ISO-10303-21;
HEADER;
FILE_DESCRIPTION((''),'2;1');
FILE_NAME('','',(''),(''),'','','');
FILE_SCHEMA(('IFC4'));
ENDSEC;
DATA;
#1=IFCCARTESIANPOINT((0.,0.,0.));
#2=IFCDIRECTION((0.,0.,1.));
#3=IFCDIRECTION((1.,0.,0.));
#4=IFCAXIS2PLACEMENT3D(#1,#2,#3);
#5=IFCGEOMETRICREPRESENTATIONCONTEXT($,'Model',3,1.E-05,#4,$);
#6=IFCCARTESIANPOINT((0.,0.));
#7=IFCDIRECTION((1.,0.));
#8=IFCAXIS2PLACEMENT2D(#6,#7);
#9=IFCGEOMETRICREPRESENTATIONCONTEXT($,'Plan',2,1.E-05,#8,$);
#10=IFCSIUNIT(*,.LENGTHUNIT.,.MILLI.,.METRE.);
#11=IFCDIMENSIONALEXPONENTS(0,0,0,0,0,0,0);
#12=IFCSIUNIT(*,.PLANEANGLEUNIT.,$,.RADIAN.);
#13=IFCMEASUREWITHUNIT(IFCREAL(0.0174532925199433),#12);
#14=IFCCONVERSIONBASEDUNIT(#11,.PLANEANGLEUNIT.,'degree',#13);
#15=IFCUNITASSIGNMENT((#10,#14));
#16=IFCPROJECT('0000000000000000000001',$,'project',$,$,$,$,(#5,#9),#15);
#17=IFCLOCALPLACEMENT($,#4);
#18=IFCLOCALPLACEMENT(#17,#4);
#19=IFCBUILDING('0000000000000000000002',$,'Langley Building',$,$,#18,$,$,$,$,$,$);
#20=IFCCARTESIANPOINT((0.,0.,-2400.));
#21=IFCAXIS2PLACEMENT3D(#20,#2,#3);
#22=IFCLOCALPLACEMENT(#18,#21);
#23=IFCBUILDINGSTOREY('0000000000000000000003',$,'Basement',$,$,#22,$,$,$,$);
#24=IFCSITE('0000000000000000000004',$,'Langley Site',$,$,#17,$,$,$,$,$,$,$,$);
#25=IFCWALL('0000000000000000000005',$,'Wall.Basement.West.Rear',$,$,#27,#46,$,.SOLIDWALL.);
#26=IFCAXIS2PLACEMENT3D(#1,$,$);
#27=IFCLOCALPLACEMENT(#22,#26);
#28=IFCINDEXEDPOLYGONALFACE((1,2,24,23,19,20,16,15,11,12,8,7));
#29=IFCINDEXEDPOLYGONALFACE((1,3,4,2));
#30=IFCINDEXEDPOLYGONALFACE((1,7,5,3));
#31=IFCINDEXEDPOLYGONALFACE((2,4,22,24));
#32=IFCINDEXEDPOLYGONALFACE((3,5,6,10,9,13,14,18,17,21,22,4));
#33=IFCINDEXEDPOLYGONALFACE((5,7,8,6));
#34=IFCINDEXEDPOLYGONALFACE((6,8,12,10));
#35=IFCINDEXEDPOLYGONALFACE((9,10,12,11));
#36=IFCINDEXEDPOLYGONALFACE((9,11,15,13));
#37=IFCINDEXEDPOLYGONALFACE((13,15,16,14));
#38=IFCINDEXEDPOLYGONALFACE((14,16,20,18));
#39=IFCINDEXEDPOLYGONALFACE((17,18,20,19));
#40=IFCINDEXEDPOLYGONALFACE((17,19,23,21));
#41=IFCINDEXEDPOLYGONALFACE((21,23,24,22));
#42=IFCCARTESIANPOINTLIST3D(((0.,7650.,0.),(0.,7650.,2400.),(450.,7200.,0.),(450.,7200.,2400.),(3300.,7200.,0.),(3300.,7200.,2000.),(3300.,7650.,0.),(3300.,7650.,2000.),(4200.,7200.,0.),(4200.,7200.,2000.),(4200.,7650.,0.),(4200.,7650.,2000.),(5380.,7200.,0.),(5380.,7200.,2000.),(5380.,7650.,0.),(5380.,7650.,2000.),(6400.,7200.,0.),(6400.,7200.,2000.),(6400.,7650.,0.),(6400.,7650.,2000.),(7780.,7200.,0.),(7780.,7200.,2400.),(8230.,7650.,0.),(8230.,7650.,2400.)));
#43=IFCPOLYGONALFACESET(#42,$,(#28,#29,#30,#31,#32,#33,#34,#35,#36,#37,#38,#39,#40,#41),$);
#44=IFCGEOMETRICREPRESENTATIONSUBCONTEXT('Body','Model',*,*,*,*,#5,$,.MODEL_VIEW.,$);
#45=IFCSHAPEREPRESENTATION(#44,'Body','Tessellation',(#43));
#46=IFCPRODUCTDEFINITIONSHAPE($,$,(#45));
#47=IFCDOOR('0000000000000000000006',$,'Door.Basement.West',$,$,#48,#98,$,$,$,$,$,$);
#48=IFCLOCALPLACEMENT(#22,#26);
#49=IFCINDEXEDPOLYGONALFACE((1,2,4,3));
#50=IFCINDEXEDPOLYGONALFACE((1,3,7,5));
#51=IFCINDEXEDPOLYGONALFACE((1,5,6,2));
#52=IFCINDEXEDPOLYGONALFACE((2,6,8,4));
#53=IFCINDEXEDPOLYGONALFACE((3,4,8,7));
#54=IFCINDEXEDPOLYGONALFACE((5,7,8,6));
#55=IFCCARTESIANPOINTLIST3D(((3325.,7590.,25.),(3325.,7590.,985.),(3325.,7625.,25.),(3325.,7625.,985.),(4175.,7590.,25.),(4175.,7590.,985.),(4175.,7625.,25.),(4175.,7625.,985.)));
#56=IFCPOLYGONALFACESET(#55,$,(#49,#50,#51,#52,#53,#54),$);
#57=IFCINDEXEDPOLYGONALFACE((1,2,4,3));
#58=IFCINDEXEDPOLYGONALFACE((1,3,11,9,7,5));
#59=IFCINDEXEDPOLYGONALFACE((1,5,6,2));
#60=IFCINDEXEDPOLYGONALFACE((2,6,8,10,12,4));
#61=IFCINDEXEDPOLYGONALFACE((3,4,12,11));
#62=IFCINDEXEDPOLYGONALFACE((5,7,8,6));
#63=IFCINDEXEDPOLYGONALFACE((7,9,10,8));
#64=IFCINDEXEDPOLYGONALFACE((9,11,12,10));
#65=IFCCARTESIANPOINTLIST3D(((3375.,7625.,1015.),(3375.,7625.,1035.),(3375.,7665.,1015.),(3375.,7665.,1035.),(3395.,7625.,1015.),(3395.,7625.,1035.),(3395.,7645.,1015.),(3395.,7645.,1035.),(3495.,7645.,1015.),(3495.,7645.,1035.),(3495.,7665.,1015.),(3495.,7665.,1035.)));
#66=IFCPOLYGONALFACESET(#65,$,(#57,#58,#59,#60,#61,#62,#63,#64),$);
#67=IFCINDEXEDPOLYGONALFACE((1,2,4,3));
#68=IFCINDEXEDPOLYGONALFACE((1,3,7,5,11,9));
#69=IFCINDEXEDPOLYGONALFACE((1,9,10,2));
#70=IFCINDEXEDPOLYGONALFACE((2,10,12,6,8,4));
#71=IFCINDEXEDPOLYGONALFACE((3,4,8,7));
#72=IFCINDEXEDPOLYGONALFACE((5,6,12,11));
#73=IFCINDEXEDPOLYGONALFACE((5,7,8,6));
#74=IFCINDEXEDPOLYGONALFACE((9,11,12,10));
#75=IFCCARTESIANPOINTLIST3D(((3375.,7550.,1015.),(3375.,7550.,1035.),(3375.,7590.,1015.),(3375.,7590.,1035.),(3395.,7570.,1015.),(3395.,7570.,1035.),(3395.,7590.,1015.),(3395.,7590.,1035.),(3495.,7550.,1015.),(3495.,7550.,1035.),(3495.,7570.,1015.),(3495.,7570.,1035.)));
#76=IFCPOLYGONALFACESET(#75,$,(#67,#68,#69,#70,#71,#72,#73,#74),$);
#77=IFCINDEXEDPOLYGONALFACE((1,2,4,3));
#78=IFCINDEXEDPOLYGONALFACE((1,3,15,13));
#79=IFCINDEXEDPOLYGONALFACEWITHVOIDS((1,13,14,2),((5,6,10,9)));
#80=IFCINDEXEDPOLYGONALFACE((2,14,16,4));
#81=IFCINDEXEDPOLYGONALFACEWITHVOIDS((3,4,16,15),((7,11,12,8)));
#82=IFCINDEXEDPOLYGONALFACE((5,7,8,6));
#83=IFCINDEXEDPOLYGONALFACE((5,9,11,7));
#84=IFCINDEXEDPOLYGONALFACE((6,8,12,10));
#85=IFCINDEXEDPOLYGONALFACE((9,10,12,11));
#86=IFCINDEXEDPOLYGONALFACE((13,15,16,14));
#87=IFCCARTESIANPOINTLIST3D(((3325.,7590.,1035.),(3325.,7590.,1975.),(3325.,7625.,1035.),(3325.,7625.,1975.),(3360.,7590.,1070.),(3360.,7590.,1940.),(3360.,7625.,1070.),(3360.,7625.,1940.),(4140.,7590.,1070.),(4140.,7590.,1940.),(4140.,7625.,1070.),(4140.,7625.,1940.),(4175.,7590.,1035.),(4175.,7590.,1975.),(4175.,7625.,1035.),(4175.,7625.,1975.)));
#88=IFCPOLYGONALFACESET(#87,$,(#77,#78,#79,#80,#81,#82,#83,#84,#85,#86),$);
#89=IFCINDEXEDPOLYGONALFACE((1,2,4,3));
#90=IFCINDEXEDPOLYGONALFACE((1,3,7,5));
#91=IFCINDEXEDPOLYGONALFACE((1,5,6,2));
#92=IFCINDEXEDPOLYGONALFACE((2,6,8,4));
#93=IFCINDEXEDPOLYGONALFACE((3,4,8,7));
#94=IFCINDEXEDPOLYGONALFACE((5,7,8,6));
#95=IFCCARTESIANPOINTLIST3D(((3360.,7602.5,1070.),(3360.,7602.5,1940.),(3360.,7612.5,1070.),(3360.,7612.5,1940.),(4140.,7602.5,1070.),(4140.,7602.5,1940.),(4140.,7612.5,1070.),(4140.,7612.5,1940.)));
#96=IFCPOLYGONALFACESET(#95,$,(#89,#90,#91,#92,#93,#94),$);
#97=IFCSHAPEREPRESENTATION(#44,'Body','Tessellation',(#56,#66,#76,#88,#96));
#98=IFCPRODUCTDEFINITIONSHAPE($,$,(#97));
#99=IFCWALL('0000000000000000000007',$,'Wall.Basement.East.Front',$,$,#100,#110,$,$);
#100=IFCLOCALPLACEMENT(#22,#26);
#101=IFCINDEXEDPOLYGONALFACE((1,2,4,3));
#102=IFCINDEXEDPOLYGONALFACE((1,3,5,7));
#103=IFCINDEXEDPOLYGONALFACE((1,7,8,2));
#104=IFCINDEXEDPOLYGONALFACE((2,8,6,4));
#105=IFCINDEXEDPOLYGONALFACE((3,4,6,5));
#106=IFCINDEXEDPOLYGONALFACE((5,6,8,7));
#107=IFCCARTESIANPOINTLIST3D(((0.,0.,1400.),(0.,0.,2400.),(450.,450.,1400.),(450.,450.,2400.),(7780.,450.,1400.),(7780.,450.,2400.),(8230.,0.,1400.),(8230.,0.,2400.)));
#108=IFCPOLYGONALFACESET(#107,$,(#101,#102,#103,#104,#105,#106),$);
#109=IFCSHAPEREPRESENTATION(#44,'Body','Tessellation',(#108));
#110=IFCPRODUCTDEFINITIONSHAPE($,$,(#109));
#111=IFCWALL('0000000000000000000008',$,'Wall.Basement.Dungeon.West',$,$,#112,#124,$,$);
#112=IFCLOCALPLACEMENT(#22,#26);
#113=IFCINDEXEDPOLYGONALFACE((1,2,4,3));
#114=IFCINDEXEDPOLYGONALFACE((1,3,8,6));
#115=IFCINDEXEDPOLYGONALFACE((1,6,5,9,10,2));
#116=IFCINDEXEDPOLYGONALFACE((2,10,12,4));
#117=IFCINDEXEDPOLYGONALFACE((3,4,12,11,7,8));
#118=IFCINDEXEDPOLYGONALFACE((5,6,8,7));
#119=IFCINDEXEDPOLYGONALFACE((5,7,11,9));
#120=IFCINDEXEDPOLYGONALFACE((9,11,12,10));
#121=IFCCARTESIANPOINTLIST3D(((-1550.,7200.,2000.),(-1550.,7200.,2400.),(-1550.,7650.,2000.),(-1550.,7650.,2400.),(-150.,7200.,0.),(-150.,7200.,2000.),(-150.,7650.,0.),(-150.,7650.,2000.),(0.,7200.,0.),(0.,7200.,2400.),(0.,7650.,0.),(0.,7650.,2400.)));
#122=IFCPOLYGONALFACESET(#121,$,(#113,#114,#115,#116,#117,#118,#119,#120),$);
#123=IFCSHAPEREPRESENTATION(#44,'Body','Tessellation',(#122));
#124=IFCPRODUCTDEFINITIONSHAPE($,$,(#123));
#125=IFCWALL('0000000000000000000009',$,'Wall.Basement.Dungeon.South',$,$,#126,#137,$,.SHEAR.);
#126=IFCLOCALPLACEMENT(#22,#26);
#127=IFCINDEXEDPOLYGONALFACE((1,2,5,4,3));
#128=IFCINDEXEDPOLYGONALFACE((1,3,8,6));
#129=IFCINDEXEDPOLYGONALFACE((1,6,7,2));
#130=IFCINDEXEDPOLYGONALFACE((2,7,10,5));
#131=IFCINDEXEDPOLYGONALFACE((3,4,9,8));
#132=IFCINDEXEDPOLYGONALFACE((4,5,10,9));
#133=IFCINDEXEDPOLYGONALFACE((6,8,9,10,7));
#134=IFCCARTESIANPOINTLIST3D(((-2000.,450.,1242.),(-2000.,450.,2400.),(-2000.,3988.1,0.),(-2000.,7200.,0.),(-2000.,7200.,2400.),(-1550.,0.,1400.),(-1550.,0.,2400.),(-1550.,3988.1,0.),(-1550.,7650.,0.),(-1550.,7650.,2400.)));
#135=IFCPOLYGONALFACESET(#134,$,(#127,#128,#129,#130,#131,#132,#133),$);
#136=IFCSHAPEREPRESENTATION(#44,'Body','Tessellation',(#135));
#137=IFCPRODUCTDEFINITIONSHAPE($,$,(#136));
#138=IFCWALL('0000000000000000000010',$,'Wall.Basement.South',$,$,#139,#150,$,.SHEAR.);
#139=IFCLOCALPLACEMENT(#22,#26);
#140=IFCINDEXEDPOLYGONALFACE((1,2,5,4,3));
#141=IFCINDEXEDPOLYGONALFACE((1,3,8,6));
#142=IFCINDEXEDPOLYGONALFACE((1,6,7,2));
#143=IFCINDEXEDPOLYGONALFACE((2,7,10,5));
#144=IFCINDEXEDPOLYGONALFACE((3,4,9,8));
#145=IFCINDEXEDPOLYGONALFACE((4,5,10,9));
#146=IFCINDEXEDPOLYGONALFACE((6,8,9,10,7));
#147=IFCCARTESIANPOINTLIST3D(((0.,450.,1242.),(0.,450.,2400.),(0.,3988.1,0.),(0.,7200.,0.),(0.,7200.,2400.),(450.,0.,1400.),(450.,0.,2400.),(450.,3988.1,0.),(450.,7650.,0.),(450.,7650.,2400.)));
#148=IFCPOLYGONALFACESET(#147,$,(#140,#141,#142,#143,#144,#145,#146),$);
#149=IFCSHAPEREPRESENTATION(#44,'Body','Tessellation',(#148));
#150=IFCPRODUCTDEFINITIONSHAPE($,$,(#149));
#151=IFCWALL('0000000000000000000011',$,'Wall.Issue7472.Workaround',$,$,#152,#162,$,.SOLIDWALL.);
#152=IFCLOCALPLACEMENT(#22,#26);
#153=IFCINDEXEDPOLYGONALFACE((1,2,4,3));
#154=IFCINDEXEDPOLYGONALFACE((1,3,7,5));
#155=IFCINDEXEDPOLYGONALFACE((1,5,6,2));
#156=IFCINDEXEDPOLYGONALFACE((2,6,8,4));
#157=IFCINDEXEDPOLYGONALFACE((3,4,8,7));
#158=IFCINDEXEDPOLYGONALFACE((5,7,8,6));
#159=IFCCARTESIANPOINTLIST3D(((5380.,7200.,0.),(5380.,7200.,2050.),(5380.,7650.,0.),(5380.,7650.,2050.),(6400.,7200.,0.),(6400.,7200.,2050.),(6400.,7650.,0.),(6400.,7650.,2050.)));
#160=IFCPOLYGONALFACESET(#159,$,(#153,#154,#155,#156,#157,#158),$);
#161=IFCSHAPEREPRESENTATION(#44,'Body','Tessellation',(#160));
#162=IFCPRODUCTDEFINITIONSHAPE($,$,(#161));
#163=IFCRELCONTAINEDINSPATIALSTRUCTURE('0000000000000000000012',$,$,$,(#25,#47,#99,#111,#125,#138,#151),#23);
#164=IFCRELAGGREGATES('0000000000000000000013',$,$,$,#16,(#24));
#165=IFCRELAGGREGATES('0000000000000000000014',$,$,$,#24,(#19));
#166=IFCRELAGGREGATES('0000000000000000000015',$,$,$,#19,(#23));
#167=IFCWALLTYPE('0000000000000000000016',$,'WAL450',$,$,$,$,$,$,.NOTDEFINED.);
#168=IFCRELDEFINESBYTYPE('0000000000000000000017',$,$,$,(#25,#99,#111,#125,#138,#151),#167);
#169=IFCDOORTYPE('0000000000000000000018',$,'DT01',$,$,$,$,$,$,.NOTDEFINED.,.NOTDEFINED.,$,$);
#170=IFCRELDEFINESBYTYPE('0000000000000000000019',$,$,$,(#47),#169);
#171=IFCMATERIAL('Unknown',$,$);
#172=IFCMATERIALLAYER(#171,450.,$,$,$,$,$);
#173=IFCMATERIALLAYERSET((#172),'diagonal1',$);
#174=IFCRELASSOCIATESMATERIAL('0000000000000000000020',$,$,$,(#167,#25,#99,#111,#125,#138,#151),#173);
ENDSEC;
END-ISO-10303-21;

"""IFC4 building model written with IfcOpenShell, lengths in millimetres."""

from ifc_helpers import new_model, entity, si_unit, converted_unit, frame, origin_with_axes, origin_2d_with_axis, place, context, subcontext, project, spatial, line, indexed_curve, outline, extrude, clip, halfspace, shape, source, transform, mapped, material, layer, layer_set, layer_usage, type_object, type_shapes, element, fill, save


model = new_model("IFC4")

# Units and contexts
model_context = context("Model", 3, precision=1e-05, world=origin_with_axes())
plan_context = context("Plan", 2, precision=1e-05, world=origin_2d_with_axis())
body_context_1 = subcontext(model_context, "Body", "Model", "MODEL_VIEW")
body_context_2 = subcontext(plan_context, "Body", "Plan", "PLAN_VIEW")
ifc_project = project(units=[si_unit("LENGTHUNIT", "METRE", prefix="MILLI"), converted_unit("PLANEANGLEUNIT", "degree", entity("IfcReal", 0.0174532925199433), si_unit("PLANEANGLEUNIT", "RADIAN"), dimensions=[0, 0, 0, 0, 0, 0, 0])], contexts=[model_context, plan_context])

# Site, building, storey
site_placement = place(None, origin_with_axes())
site = spatial("IfcSite", under=ifc_project, at=site_placement, Name="Langley Site")
building_placement = place(site_placement, origin_with_axes())
building = spatial("IfcBuilding", under=site, at=building_placement, Name="Langley Building")
storey_placement = place(building_placement, frame((0.0, 0.0, -2400.0), z_axis=(0.0, 0.0, 1.0), x_axis=(1.0, 0.0, 0.0)))
storey = spatial("IfcBuildingStorey", under=building, at=storey_placement, Name="Basement")

# Shared definitions
ifc_material = material(Name="Unknown")

# Wall, openings, door
ifc_layer_1 = layer(ifc_material, 450.0)
ifc_layer_set_1 = layer_set([ifc_layer_1], Name="diagonal1")
ifc_layer_usage_1 = layer_usage(ifc_layer_set_1, "AXIS2", "POSITIVE", 0.0)
wall_type_1 = type_object("IfcWallType", Name="WAL450", PredefinedType="NOTDEFINED", material=ifc_layer_set_1)
wall_1_placement = place(storey_placement, frame((8230.0, 7650.0, 0.0), z_axis=(0.0, 0.0, 1.0), x_axis=(-1.0, 0.0, 0.0)))
wall_1 = element("IfcWall", 1, at=wall_1_placement, inside=storey, type_object=wall_type_1, material=ifc_layer_usage_1, Name="Wall.Basement.West.Rear", PredefinedType="SOLIDWALL", context=body_context_1, shape_type="SweptSolid", body=[
    extrude(outline(indexed_curve([(0.0, 0.0), (450.0, 450.0), (7780.0, 450.0), (8230.0, 0.0)], segments=[line(1, 2, 3, 4, 1)])), origin_with_axes(), (0.0, 0.0, 1.0), 2400.0),
])
shared_shape_1 = source(origin_with_axes(), body_context_1, "Body", "SweptSolid", [
    extrude(outline(indexed_curve([(0.0, 0.0), (900.0, 0.0), (900.0, 2000.0), (0.0, 2000.0)], segments=[line(1, 2, 3, 4, 1)])), frame((0.0, -600.0, 0.0), z_axis=(0.0, -1.0, 0.0), x_axis=(1.0, 0.0, 0.0)), (0.0, 0.0, -1.0), 1200.0),
])
opening_1_placement = place(wall_1_placement, frame((4030.0, 0.0, 0.0), z_axis=(0.0, 0.0, 1.0), x_axis=(1.0, 0.0, 0.0)))
opening_1 = element("IfcOpeningElement", 2, at=opening_1_placement, cuts=wall_1, PredefinedType="OPENING", context=body_context_1, shape_type="MappedRepresentation", body=[
    mapped(shared_shape_1, transform((0.0, 0.0, 0.0), x_axis=(1.0, 0.0, 0.0), y_axis=(0.0, 1.0, 0.0), z_axis=(0.0, 0.0, 1.0), scale=1.0)),
])
shared_shape_2 = source(origin_with_axes(), body_context_1, "Body", "SweptSolid", [
    extrude(outline(indexed_curve([(0.0, 2000.0), (1020.0, 2000.0), (1020.0, 0.0), (0.0, 0.0), (0.0, 2000.0)])), frame((0.0, -600.0, 0.0), z_axis=(0.0, -1.0, 0.0), x_axis=(1.0, 0.0, 0.0)), (0.0, 0.0, -1.0), 1200.0),
])
opening_2_placement = place(wall_1_placement, frame((1830.0, 0.0, 0.0), z_axis=(0.0, 0.0, 1.0), x_axis=(1.0, 0.0, 0.0)))
element("IfcOpeningElement", 3, at=opening_2_placement, cuts=wall_1, PredefinedType="OPENING", context=body_context_1, shape_type="MappedRepresentation", body=[
    mapped(shared_shape_2, transform((0.0, 0.0, 0.0), x_axis=(1.0, 0.0, 0.0), y_axis=(0.0, 1.0, 0.0), z_axis=(0.0, 0.0, 1.0), scale=1.0)),
])
door_type_1 = type_object("IfcDoorType", Name="DT01", OperationType="NOTDEFINED", PredefinedType="NOTDEFINED")
shared_shape_3 = source(origin_with_axes(), body_context_1, "Body", "SweptSolid", [
    extrude(outline(indexed_curve([(0.0, 0.0), (850.0, 0.0), (850.0, 35.0), (0.0, 35.0)], segments=[line(1, 2, 3, 4, 1)])), frame((25.0, 25.0, 25.0), z_axis=(0.0, 0.0, 1.0), x_axis=(1.0, 0.0, 0.0)), (0.0, 0.0, 1.0), 960.0),
    extrude(outline(indexed_curve([(0.0, 0.0), (0.0, -40.0), (-120.0, -40.0), (-120.0, -20.0), (-20.0, -20.0), (-20.0, 0.0)], segments=[line(1, 2, 3, 4, 5, 6, 1)])), frame((825.0, 25.0, 1015.0), z_axis=(0.0, 0.0, 1.0), x_axis=(1.0, 0.0, 0.0)), (0.0, 0.0, 1.0), 20.0),
    extrude(outline(indexed_curve([(0.0, 0.0), (0.0, 40.0), (-120.0, 40.0), (-120.0, 20.0), (-20.0, 20.0), (-20.0, 0.0)], segments=[line(1, 2, 3, 4, 5, 6, 1)])), frame((825.0, 60.0, 1015.0), z_axis=(0.0, 0.0, 1.0), x_axis=(1.0, 0.0, 0.0)), (0.0, 0.0, 1.0), 20.0),
    extrude(outline(indexed_curve([(0.0, 0.0), (850.0, 0.0), (850.0, 940.0), (0.0, 940.0)], segments=[line(1, 2, 3, 4, 1)]), holes=[indexed_curve([(35.0, 35.0), (815.0, 35.0), (815.0, 905.0), (35.0, 905.0)], segments=[line(1, 2, 3, 4, 1)])]), frame((25.0, 25.0, 1035.0), z_axis=(0.0, -1.0, 0.0), x_axis=(1.0, 0.0, 0.0)), (0.0, 0.0, -1.0), 35.0),
    extrude(outline(indexed_curve([(35.0, 35.0), (815.0, 35.0), (815.0, 905.0), (35.0, 905.0)], segments=[line(1, 2, 3, 4, 1)])), frame((25.0, 37.5, 1035.0), z_axis=(0.0, -1.0, 0.0), x_axis=(1.0, 0.0, 0.0)), (0.0, 0.0, -1.0), 10.0),
])
shared_shape_4 = source(origin_with_axes(), body_context_2, "Body", "Curve2D", [
    entity("IfcIndexedPolyCurve", entity("IfcCartesianPointList2D", [[0.0, 0.0], [0.0, 50.0], [25.0, 50.0], [25.0, 25.0], [50.0, 25.0], [50.0, 0.0]]), [entity("IfcLineIndex", [1, 2, 3, 4, 5, 6, 1])]),
    entity("IfcIndexedPolyCurve", entity("IfcCartesianPointList2D", [[900.0, 0.0], [900.0, 50.0], [875.0, 50.0], [875.0, 25.0], [850.0, 25.0], [850.0, 0.0]]), [entity("IfcLineIndex", [1, 2, 3, 4, 5, 6, 1])]),
    entity("IfcTrimmedCurve", entity("IfcEllipse", entity("IfcAxis2Placement2D", entity("IfcCartesianPoint", [60.0, 50.0]), entity("IfcDirection", [1.0, 0.0])), 815.0, 850.0), [entity("IfcCartesianPoint", [875.0, 50.0])], [entity("IfcCartesianPoint", [60.0, 900.0])], True, "CARTESIAN"),
    entity("IfcIndexedPolyCurve", entity("IfcCartesianPointList2D", [[25.0, 50.0], [60.0, 50.0], [60.0, 900.0], [25.0, 900.0]]), [entity("IfcLineIndex", [1, 2, 3, 4, 1])]),
])
type_shapes(door_type_1, [shared_shape_3, shared_shape_4])
door_1_placement = place(opening_1_placement, origin_with_axes())
door_1 = element("IfcDoor", 4, at=door_1_placement, inside=storey, type_object=door_type_1, Name="Door.Basement.West", shapes=[
    shape(body_context_1, "Body", "MappedRepresentation", [mapped(shared_shape_3, transform((0.0, 0.0, 0.0), x_axis=(1.0, 0.0, 0.0), y_axis=(0.0, 1.0, 0.0), z_axis=(0.0, 0.0, 1.0), scale=1.0))]),
    shape(body_context_2, "Body", "MappedRepresentation", [mapped(shared_shape_4, transform((0.0, 0.0, 0.0), x_axis=(1.0, 0.0, 0.0), y_axis=(0.0, 1.0, 0.0), z_axis=(0.0, 0.0, 1.0), scale=1.0))]),
])
fill(opening_1, door_1)

# Wall
ifc_layer_usage_2 = layer_usage(ifc_layer_set_1, "AXIS2", "POSITIVE", 0.0)
wall_2_placement = place(storey_placement, frame((450.0, 0.0, 1400.0), z_axis=(0.0, 0.0, 1.0), x_axis=(1.0, 0.0, 0.0)))
element("IfcWall", 5, at=wall_2_placement, inside=storey, type_object=wall_type_1, material=ifc_layer_usage_2, Name="Wall.Basement.East.Front", context=body_context_1, shape_type="SweptSolid", body=[
    extrude(outline(indexed_curve([(-450.0, 0.0), (0.0, 450.0), (7330.0, 450.0), (7780.0, 0.0)], segments=[line(1, 2, 3, 4, 1)])), origin_with_axes(), (0.0, 0.0, 1.0), 1000.0),
])

# Wall, opening
ifc_layer_usage_3 = layer_usage(ifc_layer_set_1, "AXIS2", "POSITIVE", 0.0)
wall_3_placement = place(storey_placement, frame((0.0, 7650.0, 0.0), z_axis=(0.0, 0.0, 1.0), x_axis=(-1.0, 0.0, 0.0)))
wall_3 = element("IfcWall", 6, at=wall_3_placement, inside=storey, type_object=wall_type_1, material=ifc_layer_usage_3, Name="Wall.Basement.Dungeon.West", context=body_context_1, shape_type="SweptSolid", body=[
    extrude(outline(indexed_curve([(0.0, 0.0), (0.0, 450.0), (1550.0, 450.0), (1550.0, 0.0)], segments=[line(1, 2, 3, 4, 1)])), origin_with_axes(), (0.0, 0.0, 1.0), 2400.0),
])
opening_3_placement = place(wall_3_placement, frame((1550.0, 475.0, 0.0), z_axis=(0.0, 0.0, 1.0), x_axis=(-1.0, 0.0, 0.0)))
element("IfcOpeningElement", 7, at=opening_3_placement, cuts=wall_3, PredefinedType="OPENING", context=body_context_1, shape_type="SweptSolid", body=[
    extrude(outline(indexed_curve([(0.0, 0.0), (1400.0, 0.0), (1400.0, 500.0), (0.0, 500.0), (0.0, 0.0)])), origin_with_axes(), (0.0, 0.0, 1.0), 2000.0),
])

# Walls
ifc_layer_usage_4 = layer_usage(ifc_layer_set_1, "AXIS2", "POSITIVE", 0.0)
wall_4_placement = place(storey_placement, frame((-1550.0, 0.0, 0.0), z_axis=(0.0, 0.0, 1.0), x_axis=(0.0, 1.0, 0.0)))
element("IfcWall", 8, at=wall_4_placement, inside=storey, type_object=wall_type_1, material=ifc_layer_usage_4, Name="Wall.Basement.Dungeon.South", PredefinedType="SHEAR", context=body_context_1, shape_type="Clipping", body=[
    clip(extrude(outline(indexed_curve([(0.0, 0.0), (450.0, 450.0), (7200.0, 450.0), (7650.0, 0.0)], segments=[line(1, 2, 3, 4, 1)])), origin_with_axes(), (0.0, 0.0, 1.0), 2400.0), halfspace(frame((0.0, -50.0, 1400.0), z_axis=(-0.331226, 0.0, -0.943551), x_axis=(0.943551, -0.000001, -0.331226)), False)),
])
ifc_layer_usage_5 = layer_usage(ifc_layer_set_1, "AXIS2", "POSITIVE", 0.0)
wall_5_placement = place(storey_placement, frame((450.0, 0.0, 0.0), z_axis=(0.0, 0.0, 1.0), x_axis=(0.0, 1.0, 0.0)))
element("IfcWall", 9, at=wall_5_placement, inside=storey, type_object=wall_type_1, material=ifc_layer_usage_5, Name="Wall.Basement.South", PredefinedType="SHEAR", context=body_context_1, shape_type="Clipping", body=[
    clip(extrude(outline(indexed_curve([(0.0, 0.0), (450.0, 450.0), (7200.0, 450.0), (7650.0, 0.0)], segments=[line(1, 2, 3, 4, 1)])), origin_with_axes(), (0.0, 0.0, 1.0), 2400.0), halfspace(frame((0.0, -50.0, 1400.0), z_axis=(-0.331226, 0.0, -0.943551), x_axis=(0.943551, -0.000001, -0.331226)), False)),
])
ifc_layer_usage_6 = layer_usage(ifc_layer_set_1, "AXIS2", "POSITIVE", 0.0)
wall_6_placement = place(storey_placement, frame((5380.0, 7200.0, 0.0), z_axis=(0.0, 0.0, 1.0), x_axis=(1.0, 0.0, 0.0)))
element("IfcWall", 10, at=wall_6_placement, inside=storey, type_object=wall_type_1, material=ifc_layer_usage_6, Name="Wall.Issue7472.Workaround", PredefinedType="SOLIDWALL", context=body_context_1, shape_type="SweptSolid", body=[
    extrude(outline(indexed_curve([(0.0, 0.0), (0.0, 450.0), (1020.0, 450.0), (1020.0, 0.0)], segments=[line(1, 2, 3, 4, 1)])), origin_with_axes(), (0.0, 0.0, 1.0), 2050.0),
])

save(model, "model.ifc")
